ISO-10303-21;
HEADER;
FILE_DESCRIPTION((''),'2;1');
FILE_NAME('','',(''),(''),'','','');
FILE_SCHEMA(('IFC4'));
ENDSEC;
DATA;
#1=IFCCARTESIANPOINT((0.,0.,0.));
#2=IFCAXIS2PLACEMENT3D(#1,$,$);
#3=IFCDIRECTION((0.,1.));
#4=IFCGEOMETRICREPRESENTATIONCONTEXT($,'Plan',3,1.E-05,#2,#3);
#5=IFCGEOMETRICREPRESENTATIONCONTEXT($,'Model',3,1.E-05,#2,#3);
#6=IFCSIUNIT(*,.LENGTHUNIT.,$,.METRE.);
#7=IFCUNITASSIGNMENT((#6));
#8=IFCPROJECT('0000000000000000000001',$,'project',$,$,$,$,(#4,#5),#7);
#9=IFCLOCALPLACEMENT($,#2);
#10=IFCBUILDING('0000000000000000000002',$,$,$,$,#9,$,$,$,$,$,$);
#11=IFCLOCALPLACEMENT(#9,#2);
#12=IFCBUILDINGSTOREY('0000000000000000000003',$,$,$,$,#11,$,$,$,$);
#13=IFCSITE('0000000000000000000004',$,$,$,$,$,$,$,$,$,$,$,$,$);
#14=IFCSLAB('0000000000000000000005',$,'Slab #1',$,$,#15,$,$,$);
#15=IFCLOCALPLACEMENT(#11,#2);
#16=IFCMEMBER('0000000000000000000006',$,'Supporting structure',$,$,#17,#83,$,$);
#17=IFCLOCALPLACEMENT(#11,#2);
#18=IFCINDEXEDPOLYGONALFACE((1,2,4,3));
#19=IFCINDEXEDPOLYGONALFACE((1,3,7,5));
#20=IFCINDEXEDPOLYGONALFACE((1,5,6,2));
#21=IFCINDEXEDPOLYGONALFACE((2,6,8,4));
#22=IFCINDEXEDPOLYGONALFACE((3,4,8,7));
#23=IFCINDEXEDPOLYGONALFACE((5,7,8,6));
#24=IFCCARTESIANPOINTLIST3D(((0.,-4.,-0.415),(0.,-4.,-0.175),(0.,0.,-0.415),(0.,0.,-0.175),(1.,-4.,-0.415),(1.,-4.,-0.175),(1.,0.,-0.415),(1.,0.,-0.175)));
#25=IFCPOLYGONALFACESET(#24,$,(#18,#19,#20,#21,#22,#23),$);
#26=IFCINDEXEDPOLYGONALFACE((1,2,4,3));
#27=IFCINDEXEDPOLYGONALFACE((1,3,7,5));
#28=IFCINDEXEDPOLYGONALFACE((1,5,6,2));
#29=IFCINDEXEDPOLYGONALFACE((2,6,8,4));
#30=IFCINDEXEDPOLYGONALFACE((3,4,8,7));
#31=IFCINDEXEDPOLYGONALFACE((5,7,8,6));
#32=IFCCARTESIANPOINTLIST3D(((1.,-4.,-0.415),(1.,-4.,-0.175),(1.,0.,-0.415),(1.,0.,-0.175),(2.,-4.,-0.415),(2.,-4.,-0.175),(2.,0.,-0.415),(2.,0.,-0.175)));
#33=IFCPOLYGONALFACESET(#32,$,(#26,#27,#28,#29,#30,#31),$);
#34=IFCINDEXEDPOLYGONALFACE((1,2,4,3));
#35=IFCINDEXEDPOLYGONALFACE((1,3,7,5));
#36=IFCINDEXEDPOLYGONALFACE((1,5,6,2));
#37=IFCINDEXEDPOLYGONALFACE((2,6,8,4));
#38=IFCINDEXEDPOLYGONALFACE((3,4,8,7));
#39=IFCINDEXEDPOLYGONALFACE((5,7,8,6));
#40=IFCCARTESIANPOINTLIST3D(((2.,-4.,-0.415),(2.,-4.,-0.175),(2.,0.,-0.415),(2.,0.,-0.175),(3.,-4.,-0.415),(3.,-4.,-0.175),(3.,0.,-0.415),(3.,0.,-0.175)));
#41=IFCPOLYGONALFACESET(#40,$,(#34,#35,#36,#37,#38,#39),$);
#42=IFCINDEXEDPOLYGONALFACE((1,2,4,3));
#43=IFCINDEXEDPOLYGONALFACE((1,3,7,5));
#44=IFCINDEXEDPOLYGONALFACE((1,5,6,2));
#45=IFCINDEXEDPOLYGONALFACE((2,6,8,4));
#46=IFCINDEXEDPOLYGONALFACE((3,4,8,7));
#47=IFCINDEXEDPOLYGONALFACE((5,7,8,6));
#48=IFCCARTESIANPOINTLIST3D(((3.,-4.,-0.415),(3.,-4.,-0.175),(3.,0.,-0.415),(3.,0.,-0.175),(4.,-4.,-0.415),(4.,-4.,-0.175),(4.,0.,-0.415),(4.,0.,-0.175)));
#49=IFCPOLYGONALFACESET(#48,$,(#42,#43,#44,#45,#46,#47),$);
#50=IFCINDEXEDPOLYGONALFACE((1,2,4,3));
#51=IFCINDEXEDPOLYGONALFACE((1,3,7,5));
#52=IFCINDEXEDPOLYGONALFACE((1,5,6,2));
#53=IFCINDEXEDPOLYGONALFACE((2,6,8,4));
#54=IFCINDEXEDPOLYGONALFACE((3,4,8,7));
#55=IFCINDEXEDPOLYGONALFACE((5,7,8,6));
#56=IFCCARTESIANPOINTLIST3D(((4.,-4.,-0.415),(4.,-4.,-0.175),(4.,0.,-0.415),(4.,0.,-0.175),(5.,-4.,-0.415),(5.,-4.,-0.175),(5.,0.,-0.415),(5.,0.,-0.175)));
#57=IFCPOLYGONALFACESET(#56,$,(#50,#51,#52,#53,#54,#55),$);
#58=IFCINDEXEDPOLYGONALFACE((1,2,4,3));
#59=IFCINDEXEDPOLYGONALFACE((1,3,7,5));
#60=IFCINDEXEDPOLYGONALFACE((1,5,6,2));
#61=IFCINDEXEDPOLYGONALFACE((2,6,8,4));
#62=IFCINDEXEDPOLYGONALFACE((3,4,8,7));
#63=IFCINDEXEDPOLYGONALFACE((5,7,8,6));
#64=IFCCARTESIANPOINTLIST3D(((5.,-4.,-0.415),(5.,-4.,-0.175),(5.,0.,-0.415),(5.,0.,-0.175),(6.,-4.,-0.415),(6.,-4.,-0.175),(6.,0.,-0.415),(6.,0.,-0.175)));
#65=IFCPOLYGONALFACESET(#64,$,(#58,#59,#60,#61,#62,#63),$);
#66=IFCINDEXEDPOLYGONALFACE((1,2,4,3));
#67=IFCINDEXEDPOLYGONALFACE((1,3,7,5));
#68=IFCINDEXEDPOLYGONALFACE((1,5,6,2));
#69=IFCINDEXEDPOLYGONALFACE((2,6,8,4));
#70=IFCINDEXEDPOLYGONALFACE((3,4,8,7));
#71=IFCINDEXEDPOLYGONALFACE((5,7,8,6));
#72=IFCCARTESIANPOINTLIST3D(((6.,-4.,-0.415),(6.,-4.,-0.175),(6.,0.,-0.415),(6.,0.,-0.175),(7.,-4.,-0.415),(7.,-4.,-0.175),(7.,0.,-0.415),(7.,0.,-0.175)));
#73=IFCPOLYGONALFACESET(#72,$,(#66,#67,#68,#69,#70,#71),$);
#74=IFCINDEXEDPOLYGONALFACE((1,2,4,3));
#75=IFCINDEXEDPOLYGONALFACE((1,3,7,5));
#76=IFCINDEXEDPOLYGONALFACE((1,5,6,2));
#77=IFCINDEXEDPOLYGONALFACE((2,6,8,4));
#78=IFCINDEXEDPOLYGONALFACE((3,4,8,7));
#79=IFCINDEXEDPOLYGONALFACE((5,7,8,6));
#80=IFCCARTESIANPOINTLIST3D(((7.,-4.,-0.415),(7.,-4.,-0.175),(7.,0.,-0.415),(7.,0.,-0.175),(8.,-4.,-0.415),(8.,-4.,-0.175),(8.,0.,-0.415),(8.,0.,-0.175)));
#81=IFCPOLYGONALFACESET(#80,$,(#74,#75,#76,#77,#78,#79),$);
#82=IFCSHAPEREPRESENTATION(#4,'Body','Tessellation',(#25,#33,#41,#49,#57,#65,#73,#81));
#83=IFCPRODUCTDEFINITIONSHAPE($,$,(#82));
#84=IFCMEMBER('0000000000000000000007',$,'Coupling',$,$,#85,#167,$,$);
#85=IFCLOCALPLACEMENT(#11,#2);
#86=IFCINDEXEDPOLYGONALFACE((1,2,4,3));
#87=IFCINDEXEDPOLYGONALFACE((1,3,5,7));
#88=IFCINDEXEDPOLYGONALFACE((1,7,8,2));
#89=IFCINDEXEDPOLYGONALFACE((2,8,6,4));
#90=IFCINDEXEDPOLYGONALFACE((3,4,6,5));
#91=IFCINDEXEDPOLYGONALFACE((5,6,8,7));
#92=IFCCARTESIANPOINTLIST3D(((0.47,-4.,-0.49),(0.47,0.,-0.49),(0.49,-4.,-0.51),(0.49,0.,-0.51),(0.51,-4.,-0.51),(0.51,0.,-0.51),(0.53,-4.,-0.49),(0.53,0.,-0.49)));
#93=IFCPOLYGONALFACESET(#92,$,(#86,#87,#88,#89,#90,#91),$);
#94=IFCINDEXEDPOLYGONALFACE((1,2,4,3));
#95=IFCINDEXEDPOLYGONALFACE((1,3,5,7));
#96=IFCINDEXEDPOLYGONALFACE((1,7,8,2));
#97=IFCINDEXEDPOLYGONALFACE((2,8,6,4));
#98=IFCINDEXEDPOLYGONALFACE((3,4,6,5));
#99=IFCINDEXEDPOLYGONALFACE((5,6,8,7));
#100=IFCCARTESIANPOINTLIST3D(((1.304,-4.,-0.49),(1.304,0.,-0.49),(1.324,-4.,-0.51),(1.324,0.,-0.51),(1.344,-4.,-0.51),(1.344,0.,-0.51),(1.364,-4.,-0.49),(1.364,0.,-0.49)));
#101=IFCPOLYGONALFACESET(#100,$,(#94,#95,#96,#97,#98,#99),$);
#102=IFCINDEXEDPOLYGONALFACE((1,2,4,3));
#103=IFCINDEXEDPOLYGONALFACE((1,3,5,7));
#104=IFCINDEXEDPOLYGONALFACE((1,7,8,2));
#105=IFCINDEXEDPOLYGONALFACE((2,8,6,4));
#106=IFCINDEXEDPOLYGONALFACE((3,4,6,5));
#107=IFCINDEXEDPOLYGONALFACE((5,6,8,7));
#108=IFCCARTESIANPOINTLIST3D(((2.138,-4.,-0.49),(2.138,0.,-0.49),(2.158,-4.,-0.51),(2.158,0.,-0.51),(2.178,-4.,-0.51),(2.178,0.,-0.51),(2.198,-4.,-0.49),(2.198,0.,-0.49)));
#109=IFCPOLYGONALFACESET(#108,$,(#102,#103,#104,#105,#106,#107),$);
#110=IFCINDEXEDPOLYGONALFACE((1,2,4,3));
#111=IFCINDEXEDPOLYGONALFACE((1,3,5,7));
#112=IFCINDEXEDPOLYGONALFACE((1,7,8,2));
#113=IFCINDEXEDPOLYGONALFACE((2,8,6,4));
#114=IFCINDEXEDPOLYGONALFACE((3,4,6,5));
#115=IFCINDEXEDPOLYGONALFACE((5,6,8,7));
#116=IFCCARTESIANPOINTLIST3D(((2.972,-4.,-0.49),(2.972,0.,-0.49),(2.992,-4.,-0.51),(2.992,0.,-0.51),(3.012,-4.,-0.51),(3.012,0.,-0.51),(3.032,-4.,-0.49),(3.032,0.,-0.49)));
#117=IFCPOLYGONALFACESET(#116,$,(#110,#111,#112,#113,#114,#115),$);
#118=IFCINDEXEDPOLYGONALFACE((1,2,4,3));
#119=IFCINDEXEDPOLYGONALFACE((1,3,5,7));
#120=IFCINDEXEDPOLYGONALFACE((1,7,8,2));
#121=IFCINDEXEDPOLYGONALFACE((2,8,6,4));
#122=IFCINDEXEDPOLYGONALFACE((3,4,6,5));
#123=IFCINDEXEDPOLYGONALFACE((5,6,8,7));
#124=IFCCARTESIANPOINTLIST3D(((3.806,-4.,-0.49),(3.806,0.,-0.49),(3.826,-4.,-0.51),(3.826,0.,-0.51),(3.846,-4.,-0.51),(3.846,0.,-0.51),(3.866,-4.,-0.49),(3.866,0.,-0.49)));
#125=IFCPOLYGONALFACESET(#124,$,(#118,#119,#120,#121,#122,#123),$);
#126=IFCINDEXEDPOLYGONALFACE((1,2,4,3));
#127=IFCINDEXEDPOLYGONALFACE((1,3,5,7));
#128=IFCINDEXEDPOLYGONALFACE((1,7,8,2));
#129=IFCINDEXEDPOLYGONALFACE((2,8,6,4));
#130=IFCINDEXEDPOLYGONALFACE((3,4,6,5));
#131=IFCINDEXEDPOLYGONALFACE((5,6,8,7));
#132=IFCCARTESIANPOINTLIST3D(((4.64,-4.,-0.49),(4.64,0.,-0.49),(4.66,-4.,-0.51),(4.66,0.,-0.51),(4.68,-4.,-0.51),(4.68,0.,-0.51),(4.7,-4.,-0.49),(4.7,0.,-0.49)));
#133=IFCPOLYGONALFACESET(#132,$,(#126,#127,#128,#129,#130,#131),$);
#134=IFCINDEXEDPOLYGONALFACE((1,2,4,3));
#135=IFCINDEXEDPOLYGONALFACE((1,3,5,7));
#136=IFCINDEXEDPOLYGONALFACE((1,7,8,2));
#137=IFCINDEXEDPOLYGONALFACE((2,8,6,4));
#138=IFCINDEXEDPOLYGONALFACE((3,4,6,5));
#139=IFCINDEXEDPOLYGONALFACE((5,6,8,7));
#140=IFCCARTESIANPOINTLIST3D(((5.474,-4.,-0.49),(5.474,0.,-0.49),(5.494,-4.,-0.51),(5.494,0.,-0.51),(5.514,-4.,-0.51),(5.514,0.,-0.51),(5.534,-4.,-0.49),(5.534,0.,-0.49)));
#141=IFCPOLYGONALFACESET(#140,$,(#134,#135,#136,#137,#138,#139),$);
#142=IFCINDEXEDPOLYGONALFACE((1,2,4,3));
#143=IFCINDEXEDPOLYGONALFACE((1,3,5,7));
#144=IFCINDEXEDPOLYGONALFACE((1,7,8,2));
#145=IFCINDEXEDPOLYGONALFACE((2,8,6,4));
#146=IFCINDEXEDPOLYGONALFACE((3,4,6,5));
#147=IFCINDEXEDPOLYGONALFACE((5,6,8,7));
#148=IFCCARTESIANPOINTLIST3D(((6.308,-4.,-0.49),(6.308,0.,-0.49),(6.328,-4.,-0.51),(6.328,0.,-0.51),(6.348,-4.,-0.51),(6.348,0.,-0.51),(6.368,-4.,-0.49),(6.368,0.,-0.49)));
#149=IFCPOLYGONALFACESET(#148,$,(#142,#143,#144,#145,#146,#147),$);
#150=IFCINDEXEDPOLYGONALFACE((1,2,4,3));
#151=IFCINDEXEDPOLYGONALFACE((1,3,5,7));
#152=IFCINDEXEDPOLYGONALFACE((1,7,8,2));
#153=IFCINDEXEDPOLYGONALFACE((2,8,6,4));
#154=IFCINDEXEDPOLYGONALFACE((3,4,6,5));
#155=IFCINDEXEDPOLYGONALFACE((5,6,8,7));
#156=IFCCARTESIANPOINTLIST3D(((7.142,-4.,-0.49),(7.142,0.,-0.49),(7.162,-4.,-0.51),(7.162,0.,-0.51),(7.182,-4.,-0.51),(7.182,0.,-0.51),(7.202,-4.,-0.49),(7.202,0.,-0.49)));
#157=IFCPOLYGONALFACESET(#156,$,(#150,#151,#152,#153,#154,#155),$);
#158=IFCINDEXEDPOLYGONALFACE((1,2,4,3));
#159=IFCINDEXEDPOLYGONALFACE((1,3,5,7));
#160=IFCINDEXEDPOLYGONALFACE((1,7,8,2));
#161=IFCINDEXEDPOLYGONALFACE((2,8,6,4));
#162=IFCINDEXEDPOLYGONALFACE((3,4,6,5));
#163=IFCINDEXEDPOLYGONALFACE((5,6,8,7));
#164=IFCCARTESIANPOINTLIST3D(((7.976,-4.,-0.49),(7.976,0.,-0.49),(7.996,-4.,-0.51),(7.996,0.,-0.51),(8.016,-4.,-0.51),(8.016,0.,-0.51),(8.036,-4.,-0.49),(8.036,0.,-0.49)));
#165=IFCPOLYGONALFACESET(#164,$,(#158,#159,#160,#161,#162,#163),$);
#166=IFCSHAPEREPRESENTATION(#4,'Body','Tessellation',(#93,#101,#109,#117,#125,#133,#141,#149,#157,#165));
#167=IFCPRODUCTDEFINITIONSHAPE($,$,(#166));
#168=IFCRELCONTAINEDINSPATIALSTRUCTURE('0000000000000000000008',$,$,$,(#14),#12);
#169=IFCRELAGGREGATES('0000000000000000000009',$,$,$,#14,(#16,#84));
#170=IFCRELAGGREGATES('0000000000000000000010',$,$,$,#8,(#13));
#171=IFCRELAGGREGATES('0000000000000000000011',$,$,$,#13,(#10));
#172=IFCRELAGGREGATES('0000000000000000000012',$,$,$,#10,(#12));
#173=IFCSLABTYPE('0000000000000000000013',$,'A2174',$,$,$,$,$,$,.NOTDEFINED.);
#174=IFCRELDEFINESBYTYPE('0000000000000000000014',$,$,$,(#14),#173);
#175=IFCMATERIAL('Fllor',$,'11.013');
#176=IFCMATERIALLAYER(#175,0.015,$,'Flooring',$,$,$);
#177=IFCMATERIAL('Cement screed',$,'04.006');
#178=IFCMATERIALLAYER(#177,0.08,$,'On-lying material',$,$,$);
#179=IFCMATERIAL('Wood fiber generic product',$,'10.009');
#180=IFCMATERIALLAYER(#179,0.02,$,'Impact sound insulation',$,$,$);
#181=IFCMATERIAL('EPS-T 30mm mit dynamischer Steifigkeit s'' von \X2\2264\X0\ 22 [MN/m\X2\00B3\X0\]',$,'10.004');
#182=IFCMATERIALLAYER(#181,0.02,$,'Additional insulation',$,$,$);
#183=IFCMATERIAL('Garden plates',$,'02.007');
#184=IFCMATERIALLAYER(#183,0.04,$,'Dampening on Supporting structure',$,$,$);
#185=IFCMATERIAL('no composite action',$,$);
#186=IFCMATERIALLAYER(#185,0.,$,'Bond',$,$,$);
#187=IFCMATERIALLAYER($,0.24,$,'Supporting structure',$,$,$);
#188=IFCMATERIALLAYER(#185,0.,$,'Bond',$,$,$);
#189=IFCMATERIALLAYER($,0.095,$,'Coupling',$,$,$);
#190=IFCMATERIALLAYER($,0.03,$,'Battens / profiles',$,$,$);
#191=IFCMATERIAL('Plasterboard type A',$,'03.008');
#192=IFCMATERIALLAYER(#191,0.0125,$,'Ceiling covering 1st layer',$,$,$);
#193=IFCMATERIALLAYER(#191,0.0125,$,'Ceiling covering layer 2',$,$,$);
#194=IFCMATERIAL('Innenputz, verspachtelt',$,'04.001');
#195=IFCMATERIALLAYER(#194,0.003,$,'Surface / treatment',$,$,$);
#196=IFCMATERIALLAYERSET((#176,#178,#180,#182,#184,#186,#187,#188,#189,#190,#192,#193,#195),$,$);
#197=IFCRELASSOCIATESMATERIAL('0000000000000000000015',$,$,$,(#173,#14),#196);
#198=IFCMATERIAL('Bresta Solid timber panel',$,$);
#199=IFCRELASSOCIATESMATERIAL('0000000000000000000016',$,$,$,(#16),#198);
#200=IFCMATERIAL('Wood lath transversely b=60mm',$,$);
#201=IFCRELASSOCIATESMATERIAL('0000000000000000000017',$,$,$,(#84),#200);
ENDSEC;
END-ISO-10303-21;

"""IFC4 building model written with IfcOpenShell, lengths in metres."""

from ifc_helpers import new_model, si_unit, direction, frame, frame_2d, origin, place, context, project, spatial, polyline, rectangle, outline, extrude, material, layer, layer_set, type_object, element, aggregate, save


model = new_model("IFC4")

# Units and contexts
plan_context = context("Plan", 3, precision=1e-05, world=origin(), true_north=direction((0.0, 1.0)))
model_context = context("Model", 3, precision=1e-05, world=origin(), true_north=direction((0.0, 1.0)))
ifc_project = project(units=[si_unit("LENGTHUNIT", "METRE")], contexts=[plan_context, model_context])

# Site, building, storey
site = spatial("IfcSite", under=ifc_project)
building_placement = place(None, origin())
building = spatial("IfcBuilding", under=site, at=building_placement)
storey_placement = place(building_placement, origin())
storey = spatial("IfcBuildingStorey", under=building, at=storey_placement)

# Slab, members
ifc_material_1 = material(Name="Fllor", Category="11.013")
ifc_layer_1 = layer(ifc_material_1, 0.015, Name="Flooring")
ifc_material_2 = material(Name="Cement screed", Category="04.006")
ifc_layer_2 = layer(ifc_material_2, 0.08, Name="On-lying material")
ifc_material_3 = material(Name="Wood fiber generic product", Category="10.009")
ifc_layer_3 = layer(ifc_material_3, 0.02, Name="Impact sound insulation")
ifc_material_4 = material(Name="EPS-T 30mm mit dynamischer Steifigkeit s' von ≤ 22 [MN/m³]", Category="10.004")
ifc_layer_4 = layer(ifc_material_4, 0.02, Name="Additional insulation")
ifc_material_5 = material(Name="Garden plates", Category="02.007")
ifc_layer_5 = layer(ifc_material_5, 0.04, Name="Dampening on Supporting structure")
ifc_material_6 = material(Name="no composite action")
ifc_layer_6 = layer(ifc_material_6, 0.0, Name="Bond")
ifc_layer_7 = layer(None, 0.24, Name="Supporting structure")
ifc_layer_8 = layer(ifc_material_6, 0.0, Name="Bond")
ifc_layer_9 = layer(None, 0.095, Name="Coupling")
ifc_layer_10 = layer(None, 0.03, Name="Battens / profiles")
ifc_material_7 = material(Name="Plasterboard type A", Category="03.008")
ifc_layer_11 = layer(ifc_material_7, 0.0125, Name="Ceiling covering 1st layer")
ifc_layer_12 = layer(ifc_material_7, 0.0125, Name="Ceiling covering layer 2")
ifc_material_8 = material(Name="Innenputz, verspachtelt", Category="04.001")
ifc_layer_13 = layer(ifc_material_8, 0.003, Name="Surface / treatment")
ifc_layer_set = layer_set([ifc_layer_1, ifc_layer_2, ifc_layer_3, ifc_layer_4, ifc_layer_5, ifc_layer_6, ifc_layer_7, ifc_layer_8, ifc_layer_9, ifc_layer_10, ifc_layer_11, ifc_layer_12, ifc_layer_13])
slab_type = type_object("IfcSlabType", Name="A2174", PredefinedType="NOTDEFINED", material=ifc_layer_set)
slab_placement = place(None, frame((0.0, 0.0, 0.0), z_axis=(0.0, 0.0, -1.0), x_axis=(1.0, 0.0, 0.0)))
slab = element("IfcSlab", 1, at=slab_placement, inside=storey, type_object=slab_type, material=ifc_layer_set, Name="Slab #1")
ifc_material_9 = material(Name="Bresta Solid timber panel")
member_1_placement = place(slab_placement, origin())
member_1 = element("IfcMember", 2, at=member_1_placement, material=ifc_material_9, Name="Supporting structure", context=plan_context, shape_type="SweptSolid", body=[
    extrude(rectangle(XDim=1.0, YDim=0.24, at=frame_2d((0.5, 0.12), x_axis=(1.0, 0.0))), frame((0.0, 4.0, 0.175), z_axis=(0.0, -1.0, 0.0), x_axis=(1.0, 0.0, 0.0)), (0.0, 0.0, 1.0), 4.0),
    extrude(rectangle(XDim=1.0, YDim=0.24, at=frame_2d((0.5, 0.12), x_axis=(1.0, 0.0))), frame((1.0, 4.0, 0.175), z_axis=(0.0, -1.0, 0.0), x_axis=(1.0, 0.0, 0.0)), (0.0, 0.0, 1.0), 4.0),
    extrude(rectangle(XDim=1.0, YDim=0.24, at=frame_2d((0.5, 0.12), x_axis=(1.0, 0.0))), frame((2.0, 4.0, 0.175), z_axis=(0.0, -1.0, 0.0), x_axis=(1.0, 0.0, 0.0)), (0.0, 0.0, 1.0), 4.0),
    extrude(rectangle(XDim=1.0, YDim=0.24, at=frame_2d((0.5, 0.12), x_axis=(1.0, 0.0))), frame((3.0, 4.0, 0.175), z_axis=(0.0, -1.0, 0.0), x_axis=(1.0, 0.0, 0.0)), (0.0, 0.0, 1.0), 4.0),
    extrude(rectangle(XDim=1.0, YDim=0.24, at=frame_2d((0.5, 0.12), x_axis=(1.0, 0.0))), frame((4.0, 4.0, 0.175), z_axis=(0.0, -1.0, 0.0), x_axis=(1.0, 0.0, 0.0)), (0.0, 0.0, 1.0), 4.0),
    extrude(rectangle(XDim=1.0, YDim=0.24, at=frame_2d((0.5, 0.12), x_axis=(1.0, 0.0))), frame((5.0, 4.0, 0.175), z_axis=(0.0, -1.0, 0.0), x_axis=(1.0, 0.0, 0.0)), (0.0, 0.0, 1.0), 4.0),
    extrude(rectangle(XDim=1.0, YDim=0.24, at=frame_2d((0.5, 0.12), x_axis=(1.0, 0.0))), frame((6.0, 4.0, 0.175), z_axis=(0.0, -1.0, 0.0), x_axis=(1.0, 0.0, 0.0)), (0.0, 0.0, 1.0), 4.0),
    extrude(rectangle(XDim=1.0, YDim=0.24, at=frame_2d((0.5, 0.12), x_axis=(1.0, 0.0))), frame((7.0, 4.0, 0.175), z_axis=(0.0, -1.0, 0.0), x_axis=(1.0, 0.0, 0.0)), (0.0, 0.0, 1.0), 4.0),
])
ifc_material_10 = material(Name="Wood lath transversely b=60mm")
member_2_placement = place(slab_placement, origin())
member_2 = element("IfcMember", 3, at=member_2_placement, material=ifc_material_10, Name="Coupling", context=plan_context, shape_type="SweptSolid", body=[
    extrude(outline(polyline([(0.0, 0.0), (0.06, 0.0), (0.04, 0.02), (0.02, 0.02), (0.0, 0.0)])), frame((0.47, 4.0, 0.49), z_axis=(0.0, -1.0, 0.0), x_axis=(1.0, 0.0, 0.0)), (0.0, 0.0, 1.0), 4.0),
    extrude(outline(polyline([(0.0, 0.0), (0.06, 0.0), (0.04, 0.02), (0.02, 0.02), (0.0, 0.0)])), frame((1.304, 4.0, 0.49), z_axis=(0.0, -1.0, 0.0), x_axis=(1.0, 0.0, 0.0)), (0.0, 0.0, 1.0), 4.0),
    extrude(outline(polyline([(0.0, 0.0), (0.06, 0.0), (0.04, 0.02), (0.02, 0.02), (0.0, 0.0)])), frame((2.138, 4.0, 0.49), z_axis=(0.0, -1.0, 0.0), x_axis=(1.0, 0.0, 0.0)), (0.0, 0.0, 1.0), 4.0),
    extrude(outline(polyline([(0.0, 0.0), (0.06, 0.0), (0.04, 0.02), (0.02, 0.02), (0.0, 0.0)])), frame((2.972, 4.0, 0.49), z_axis=(0.0, -1.0, 0.0), x_axis=(1.0, 0.0, 0.0)), (0.0, 0.0, 1.0), 4.0),
    extrude(outline(polyline([(0.0, 0.0), (0.06, 0.0), (0.04, 0.02), (0.02, 0.02), (0.0, 0.0)])), frame((3.806, 4.0, 0.49), z_axis=(0.0, -1.0, 0.0), x_axis=(1.0, 0.0, 0.0)), (0.0, 0.0, 1.0), 4.0),
    extrude(outline(polyline([(0.0, 0.0), (0.06, 0.0), (0.04, 0.02), (0.02, 0.02), (0.0, 0.0)])), frame((4.64, 4.0, 0.49), z_axis=(0.0, -1.0, 0.0), x_axis=(1.0, 0.0, 0.0)), (0.0, 0.0, 1.0), 4.0),
    extrude(outline(polyline([(0.0, 0.0), (0.06, 0.0), (0.04, 0.02), (0.02, 0.02), (0.0, 0.0)])), frame((5.474, 4.0, 0.49), z_axis=(0.0, -1.0, 0.0), x_axis=(1.0, 0.0, 0.0)), (0.0, 0.0, 1.0), 4.0),
    extrude(outline(polyline([(0.0, 0.0), (0.06, 0.0), (0.04, 0.02), (0.02, 0.02), (0.0, 0.0)])), frame((6.308, 4.0, 0.49), z_axis=(0.0, -1.0, 0.0), x_axis=(1.0, 0.0, 0.0)), (0.0, 0.0, 1.0), 4.0),
    extrude(outline(polyline([(0.0, 0.0), (0.06, 0.0), (0.04, 0.02), (0.02, 0.02), (0.0, 0.0)])), frame((7.142, 4.0, 0.49), z_axis=(0.0, -1.0, 0.0), x_axis=(1.0, 0.0, 0.0)), (0.0, 0.0, 1.0), 4.0),
    extrude(outline(polyline([(0.0, 0.0), (0.06, 0.0), (0.04, 0.02), (0.02, 0.02), (0.0, 0.0)])), frame((7.976, 4.0, 0.49), z_axis=(0.0, -1.0, 0.0), x_axis=(1.0, 0.0, 0.0)), (0.0, 0.0, 1.0), 4.0),
])
aggregate(slab, [member_1, member_2])

save(model, "model.ifc")
